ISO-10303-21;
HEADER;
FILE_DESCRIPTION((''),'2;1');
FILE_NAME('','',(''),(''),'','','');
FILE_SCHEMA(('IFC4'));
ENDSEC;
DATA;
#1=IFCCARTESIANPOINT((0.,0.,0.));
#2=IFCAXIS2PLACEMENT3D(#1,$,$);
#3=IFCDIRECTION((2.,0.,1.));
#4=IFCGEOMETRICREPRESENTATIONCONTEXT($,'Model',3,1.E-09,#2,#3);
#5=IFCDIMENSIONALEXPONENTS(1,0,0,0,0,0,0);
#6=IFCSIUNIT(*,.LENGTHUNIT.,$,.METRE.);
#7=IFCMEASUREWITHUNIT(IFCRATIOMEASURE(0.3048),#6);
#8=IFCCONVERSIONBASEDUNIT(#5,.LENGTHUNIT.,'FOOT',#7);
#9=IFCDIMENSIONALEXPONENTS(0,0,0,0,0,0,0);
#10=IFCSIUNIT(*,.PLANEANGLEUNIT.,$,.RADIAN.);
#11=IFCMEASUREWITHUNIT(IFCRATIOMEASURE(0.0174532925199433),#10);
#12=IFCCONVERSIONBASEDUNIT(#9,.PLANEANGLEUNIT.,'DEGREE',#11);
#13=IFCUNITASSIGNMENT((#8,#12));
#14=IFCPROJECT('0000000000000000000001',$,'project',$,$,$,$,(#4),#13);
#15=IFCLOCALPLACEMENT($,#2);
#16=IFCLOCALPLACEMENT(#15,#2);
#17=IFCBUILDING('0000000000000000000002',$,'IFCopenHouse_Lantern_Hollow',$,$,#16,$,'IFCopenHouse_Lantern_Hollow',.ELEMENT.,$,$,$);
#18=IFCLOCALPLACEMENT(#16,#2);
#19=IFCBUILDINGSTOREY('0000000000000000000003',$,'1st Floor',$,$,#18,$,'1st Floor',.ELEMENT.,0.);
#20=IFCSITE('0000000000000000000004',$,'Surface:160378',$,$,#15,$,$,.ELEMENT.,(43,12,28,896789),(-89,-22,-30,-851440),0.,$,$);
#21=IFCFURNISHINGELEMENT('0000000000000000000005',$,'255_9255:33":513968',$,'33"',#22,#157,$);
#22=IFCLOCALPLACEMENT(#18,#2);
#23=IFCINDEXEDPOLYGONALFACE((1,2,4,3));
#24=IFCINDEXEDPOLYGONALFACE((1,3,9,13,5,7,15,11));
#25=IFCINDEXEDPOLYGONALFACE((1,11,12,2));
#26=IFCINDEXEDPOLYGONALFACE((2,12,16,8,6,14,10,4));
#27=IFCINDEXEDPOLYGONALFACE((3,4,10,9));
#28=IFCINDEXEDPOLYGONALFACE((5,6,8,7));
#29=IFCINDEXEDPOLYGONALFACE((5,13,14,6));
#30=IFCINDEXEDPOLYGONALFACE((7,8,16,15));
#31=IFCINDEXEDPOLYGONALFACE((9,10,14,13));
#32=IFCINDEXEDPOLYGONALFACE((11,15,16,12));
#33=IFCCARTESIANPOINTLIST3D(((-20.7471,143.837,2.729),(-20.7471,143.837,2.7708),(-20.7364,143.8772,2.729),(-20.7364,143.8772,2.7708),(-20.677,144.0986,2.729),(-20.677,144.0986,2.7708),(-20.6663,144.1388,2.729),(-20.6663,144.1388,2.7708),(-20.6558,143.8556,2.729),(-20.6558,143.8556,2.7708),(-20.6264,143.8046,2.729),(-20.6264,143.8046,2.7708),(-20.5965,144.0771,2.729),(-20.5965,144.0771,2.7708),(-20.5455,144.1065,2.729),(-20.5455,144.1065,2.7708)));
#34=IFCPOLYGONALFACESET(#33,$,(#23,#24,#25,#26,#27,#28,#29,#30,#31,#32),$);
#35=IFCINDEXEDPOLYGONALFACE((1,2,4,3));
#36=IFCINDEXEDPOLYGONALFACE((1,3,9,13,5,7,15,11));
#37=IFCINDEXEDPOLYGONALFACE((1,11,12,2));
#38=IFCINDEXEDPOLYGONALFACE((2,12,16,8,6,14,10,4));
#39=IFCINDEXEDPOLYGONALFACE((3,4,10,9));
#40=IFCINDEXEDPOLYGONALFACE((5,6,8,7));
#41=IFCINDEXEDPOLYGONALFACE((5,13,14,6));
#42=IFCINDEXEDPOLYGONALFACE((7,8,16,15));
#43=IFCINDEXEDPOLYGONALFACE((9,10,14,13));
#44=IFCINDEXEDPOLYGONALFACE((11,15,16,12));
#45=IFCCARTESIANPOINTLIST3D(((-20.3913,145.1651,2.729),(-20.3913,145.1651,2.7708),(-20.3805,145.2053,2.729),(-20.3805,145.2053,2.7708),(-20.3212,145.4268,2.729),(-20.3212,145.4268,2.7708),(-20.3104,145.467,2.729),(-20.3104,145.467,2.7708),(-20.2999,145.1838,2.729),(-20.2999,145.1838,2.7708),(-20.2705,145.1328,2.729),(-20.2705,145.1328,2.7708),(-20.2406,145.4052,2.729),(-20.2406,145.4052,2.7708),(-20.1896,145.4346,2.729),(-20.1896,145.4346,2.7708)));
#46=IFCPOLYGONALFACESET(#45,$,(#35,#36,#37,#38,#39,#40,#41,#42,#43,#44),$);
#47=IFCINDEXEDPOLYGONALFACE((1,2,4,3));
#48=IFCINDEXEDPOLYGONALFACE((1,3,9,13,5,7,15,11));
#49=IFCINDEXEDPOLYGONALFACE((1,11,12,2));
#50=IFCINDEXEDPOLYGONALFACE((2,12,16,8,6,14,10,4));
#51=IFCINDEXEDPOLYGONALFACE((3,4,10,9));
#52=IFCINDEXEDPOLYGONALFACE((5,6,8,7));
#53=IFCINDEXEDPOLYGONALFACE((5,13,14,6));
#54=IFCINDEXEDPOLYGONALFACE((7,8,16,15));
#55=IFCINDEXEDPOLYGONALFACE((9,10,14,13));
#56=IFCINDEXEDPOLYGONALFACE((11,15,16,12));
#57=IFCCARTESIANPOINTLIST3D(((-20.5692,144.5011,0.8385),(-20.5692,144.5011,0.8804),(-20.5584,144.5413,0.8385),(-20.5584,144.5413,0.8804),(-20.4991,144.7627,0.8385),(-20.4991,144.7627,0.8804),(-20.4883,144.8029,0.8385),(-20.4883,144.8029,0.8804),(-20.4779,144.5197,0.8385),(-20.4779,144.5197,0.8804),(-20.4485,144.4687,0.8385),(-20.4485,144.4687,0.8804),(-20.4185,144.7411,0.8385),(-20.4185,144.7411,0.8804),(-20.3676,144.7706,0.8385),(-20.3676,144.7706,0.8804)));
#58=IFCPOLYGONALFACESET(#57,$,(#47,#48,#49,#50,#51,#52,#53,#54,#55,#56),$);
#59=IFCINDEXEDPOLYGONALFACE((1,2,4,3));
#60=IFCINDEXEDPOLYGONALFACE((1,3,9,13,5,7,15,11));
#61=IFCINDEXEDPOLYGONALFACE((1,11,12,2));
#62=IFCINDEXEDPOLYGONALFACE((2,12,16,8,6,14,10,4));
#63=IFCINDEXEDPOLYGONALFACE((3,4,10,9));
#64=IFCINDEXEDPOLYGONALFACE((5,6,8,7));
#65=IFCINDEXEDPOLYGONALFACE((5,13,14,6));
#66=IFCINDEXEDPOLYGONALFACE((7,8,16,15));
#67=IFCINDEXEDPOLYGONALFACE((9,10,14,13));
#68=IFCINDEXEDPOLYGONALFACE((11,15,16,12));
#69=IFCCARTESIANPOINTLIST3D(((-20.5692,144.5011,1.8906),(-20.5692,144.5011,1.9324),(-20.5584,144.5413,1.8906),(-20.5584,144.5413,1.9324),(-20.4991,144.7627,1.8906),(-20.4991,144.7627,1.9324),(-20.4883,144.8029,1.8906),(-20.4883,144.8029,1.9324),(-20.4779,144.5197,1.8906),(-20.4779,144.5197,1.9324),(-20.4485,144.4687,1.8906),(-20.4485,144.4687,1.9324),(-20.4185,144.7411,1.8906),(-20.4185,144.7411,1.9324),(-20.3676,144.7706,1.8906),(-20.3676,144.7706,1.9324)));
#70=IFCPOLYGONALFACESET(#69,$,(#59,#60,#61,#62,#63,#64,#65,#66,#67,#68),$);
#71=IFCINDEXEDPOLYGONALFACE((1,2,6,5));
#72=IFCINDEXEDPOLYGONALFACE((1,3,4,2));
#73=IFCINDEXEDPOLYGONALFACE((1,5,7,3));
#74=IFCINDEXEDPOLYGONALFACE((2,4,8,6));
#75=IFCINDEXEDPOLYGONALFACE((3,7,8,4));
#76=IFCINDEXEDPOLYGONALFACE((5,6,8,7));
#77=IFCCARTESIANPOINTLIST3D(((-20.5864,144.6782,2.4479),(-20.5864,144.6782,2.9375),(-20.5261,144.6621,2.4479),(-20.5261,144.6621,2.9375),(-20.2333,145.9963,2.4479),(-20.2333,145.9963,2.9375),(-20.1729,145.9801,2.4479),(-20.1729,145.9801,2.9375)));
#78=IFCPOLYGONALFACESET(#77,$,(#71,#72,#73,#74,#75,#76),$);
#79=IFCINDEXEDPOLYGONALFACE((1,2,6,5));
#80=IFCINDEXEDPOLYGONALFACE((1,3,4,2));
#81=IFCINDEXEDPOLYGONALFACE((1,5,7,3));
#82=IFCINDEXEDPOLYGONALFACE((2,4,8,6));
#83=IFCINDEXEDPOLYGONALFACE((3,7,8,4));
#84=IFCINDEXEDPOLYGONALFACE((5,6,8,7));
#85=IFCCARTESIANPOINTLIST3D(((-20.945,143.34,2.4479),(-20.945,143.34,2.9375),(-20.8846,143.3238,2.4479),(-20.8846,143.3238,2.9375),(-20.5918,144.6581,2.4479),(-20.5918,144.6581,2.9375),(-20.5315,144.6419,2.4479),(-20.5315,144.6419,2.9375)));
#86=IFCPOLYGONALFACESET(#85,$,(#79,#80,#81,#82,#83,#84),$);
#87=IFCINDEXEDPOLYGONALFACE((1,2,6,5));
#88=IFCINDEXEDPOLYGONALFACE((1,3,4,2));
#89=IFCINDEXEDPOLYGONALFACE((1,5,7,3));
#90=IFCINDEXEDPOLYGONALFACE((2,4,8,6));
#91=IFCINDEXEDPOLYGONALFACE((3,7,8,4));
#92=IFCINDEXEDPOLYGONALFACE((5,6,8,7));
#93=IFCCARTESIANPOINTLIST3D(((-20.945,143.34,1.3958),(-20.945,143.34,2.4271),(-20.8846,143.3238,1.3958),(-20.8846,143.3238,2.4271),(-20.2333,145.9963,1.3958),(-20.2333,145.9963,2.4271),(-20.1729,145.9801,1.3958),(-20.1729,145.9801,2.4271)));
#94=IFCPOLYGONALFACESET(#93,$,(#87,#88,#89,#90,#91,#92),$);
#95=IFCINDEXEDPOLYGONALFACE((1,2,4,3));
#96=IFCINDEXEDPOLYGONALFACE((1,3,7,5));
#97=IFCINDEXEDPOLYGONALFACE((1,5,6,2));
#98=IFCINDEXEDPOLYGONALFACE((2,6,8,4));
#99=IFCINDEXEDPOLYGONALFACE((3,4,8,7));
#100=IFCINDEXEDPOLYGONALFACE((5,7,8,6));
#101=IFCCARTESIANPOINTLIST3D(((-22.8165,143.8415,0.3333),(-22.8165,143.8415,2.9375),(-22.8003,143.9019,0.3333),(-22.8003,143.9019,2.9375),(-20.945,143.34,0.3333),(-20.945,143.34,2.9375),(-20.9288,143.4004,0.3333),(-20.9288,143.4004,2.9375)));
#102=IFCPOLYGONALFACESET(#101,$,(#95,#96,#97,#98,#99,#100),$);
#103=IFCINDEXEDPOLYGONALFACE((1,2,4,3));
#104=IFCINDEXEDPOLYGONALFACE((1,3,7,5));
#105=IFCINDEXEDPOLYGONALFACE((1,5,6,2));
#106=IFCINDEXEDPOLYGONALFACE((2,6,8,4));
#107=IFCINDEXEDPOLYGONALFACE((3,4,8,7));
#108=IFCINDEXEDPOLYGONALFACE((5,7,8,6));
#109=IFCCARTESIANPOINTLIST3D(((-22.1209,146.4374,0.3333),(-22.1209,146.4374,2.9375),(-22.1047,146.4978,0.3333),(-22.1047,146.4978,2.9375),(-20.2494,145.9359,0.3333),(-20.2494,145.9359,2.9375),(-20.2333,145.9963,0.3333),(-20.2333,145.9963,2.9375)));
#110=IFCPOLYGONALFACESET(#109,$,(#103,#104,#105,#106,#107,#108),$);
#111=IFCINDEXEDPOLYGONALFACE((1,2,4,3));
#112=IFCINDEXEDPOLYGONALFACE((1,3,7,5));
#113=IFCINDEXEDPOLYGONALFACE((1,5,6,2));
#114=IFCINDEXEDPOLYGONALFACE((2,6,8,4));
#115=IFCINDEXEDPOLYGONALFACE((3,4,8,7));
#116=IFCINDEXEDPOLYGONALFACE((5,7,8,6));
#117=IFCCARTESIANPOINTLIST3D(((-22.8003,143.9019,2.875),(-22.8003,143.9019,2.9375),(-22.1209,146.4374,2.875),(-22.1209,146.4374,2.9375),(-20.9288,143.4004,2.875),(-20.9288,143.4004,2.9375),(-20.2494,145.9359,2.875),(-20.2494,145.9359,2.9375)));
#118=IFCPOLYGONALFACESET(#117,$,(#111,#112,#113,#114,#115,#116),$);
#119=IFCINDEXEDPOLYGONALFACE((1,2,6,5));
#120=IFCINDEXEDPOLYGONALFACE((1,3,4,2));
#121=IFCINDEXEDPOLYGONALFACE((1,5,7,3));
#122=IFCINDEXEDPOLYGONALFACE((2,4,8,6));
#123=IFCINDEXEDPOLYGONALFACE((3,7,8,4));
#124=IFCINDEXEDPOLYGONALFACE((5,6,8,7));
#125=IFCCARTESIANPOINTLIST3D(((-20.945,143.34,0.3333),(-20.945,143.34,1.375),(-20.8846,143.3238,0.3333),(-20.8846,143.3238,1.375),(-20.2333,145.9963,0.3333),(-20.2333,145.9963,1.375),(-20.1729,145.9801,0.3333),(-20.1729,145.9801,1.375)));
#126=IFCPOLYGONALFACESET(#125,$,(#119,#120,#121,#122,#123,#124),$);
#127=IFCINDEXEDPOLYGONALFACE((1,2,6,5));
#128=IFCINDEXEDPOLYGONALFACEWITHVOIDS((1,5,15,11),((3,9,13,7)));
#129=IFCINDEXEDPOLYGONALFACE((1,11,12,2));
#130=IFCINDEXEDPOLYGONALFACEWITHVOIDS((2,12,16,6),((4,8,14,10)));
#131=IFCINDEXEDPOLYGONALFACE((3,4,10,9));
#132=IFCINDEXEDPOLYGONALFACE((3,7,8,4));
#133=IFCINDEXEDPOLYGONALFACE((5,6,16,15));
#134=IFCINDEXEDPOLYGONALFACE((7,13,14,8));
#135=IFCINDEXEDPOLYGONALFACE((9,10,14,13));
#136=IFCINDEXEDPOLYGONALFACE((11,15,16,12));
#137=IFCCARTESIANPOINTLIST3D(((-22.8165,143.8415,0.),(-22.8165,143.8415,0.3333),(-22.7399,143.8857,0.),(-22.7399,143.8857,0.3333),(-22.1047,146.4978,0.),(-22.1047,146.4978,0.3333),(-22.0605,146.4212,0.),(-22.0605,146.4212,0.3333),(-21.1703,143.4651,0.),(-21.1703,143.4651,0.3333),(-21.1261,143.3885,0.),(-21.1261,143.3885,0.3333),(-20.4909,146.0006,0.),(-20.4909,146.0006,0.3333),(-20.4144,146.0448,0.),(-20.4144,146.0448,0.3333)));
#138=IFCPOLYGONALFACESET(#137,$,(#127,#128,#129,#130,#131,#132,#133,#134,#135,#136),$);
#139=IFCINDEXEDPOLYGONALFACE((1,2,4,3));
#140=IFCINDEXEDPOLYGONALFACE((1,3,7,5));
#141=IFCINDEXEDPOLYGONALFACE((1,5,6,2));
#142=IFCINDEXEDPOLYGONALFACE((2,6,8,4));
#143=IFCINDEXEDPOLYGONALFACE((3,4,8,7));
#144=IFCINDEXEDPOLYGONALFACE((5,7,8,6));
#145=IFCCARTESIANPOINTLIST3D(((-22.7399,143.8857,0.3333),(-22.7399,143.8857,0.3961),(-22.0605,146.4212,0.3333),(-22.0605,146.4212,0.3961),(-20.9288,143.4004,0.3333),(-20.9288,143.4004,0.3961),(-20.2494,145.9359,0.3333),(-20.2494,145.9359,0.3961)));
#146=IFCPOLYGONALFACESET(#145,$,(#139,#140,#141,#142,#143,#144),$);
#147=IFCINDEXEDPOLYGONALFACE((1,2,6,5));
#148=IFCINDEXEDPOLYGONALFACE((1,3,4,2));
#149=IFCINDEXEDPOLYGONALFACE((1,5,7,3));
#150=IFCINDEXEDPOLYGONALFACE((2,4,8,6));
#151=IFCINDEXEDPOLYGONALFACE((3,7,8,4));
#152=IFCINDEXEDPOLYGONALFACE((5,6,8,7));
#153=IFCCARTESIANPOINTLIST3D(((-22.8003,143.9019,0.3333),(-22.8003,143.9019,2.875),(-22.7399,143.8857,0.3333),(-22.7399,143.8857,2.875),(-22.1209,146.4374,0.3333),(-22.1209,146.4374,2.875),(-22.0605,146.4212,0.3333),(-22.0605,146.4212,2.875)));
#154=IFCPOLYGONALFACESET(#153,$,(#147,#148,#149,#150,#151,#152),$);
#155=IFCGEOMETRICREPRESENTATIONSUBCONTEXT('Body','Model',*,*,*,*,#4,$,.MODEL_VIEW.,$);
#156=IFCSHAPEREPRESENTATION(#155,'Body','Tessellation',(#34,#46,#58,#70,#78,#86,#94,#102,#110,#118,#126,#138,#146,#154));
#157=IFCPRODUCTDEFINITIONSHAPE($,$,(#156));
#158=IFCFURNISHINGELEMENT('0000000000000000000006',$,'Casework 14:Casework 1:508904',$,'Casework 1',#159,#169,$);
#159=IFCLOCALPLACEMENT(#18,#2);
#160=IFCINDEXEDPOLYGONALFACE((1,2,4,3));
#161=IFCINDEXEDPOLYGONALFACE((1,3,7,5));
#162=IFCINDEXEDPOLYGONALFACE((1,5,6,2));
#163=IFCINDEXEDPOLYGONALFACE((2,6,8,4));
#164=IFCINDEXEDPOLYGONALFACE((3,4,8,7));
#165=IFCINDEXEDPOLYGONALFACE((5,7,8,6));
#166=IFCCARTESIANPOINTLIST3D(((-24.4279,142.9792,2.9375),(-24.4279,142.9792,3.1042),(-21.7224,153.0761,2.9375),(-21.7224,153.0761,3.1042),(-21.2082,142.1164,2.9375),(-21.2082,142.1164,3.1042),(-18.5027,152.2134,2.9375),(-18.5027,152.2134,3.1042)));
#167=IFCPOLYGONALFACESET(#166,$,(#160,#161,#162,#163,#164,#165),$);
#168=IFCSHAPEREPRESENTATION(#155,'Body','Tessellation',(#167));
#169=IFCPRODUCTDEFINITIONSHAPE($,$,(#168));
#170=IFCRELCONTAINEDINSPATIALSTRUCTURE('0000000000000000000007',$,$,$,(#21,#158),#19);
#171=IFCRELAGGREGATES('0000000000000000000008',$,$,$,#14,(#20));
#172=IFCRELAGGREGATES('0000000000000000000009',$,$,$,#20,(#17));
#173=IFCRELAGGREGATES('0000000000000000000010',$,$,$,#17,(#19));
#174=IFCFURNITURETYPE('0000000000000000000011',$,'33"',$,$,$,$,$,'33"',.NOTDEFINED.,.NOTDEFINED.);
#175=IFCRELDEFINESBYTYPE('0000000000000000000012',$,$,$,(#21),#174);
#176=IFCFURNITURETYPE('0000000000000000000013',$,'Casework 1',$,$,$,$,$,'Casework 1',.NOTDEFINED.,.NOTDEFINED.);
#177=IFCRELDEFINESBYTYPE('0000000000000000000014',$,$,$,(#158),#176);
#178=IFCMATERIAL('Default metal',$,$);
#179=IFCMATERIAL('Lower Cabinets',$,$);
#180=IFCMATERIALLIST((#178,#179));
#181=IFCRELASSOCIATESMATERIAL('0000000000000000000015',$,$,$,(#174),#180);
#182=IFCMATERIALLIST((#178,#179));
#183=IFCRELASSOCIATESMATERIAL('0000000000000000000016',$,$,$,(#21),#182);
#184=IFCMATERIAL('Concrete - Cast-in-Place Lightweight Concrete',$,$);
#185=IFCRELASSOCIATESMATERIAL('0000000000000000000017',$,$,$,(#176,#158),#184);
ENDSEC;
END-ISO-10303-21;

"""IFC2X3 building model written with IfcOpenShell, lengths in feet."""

from ifc_helpers import new_model, entity, si_unit, converted_unit, direction, frame, frame_2d, origin, origin_2d_with_axis, place, context, subcontext, project, spatial, polyline, rectangle, outline, extrude, source, transform, mapped, material, material_list, type_object, type_shapes, element, save


model = new_model("IFC2X3")

# Units and contexts
model_context = context("Model", 3, precision=1e-09, world=origin(), true_north=direction((2.0, 0.0, 1.0)))
body_context = subcontext(model_context, "Body", "Model", "MODEL_VIEW")
ifc_project = project(units=[converted_unit("LENGTHUNIT", "FOOT", entity("IfcRatioMeasure", 0.3048), si_unit("LENGTHUNIT", "METRE"), dimensions=[1, 0, 0, 0, 0, 0, 0]), converted_unit("PLANEANGLEUNIT", "DEGREE", entity("IfcRatioMeasure", 0.0174532925199433), si_unit("PLANEANGLEUNIT", "RADIAN"), dimensions=[0, 0, 0, 0, 0, 0, 0])], contexts=[model_context])

# Site, building, storey
site_placement = place(None, origin())
site = spatial("IfcSite", under=ifc_project, at=site_placement, Name="Surface:160378", CompositionType="ELEMENT", RefLatitude=(43, 12, 28, 896789), RefLongitude=(-89, -22, -30, -851440), RefElevation=0.0)
building_placement = place(site_placement, origin())
building = spatial("IfcBuilding", under=site, at=building_placement, Name="IFCopenHouse_Lantern_Hollow", LongName="IFCopenHouse_Lantern_Hollow", CompositionType="ELEMENT")
storey_placement = place(building_placement, origin())
storey = spatial("IfcBuildingStorey", under=building, at=storey_placement, Name="1st Floor", LongName="1st Floor", CompositionType="ELEMENT", Elevation=0.0)

# Furnishing elements
ifc_material_1 = material(Name="Default metal")
ifc_material_2 = material(Name="Lower Cabinets")
ifc_material_list_1 = material_list([ifc_material_1, ifc_material_2])
ifc_material_list_2 = material_list([ifc_material_1, ifc_material_2])
furniture_type_1 = type_object("IfcFurnitureType", Name="33\"", ElementType="33\"", AssemblyPlace="NOTDEFINED", material=ifc_material_list_2)
shared_shape_1 = source(origin(), body_context, "Body", "SweptSolid", [
    extrude(outline(polyline([(-0.0521, -0.1562), (0.0729, -0.1562), (0.0729, 0.1562), (-0.0521, 0.1562), (-0.0521, 0.1146), (0.0313, 0.1146), (0.0313, -0.1146), (-0.0521, -0.1146), (-0.0521, -0.1562)])), frame((-0.626, -2.0521, 2.729), z_axis=(0.0, 0.0, 1.0), x_axis=(0.0, -1.0, 0.0)), (0.0, 0.0, 1.0), 0.0418),
    extrude(outline(polyline([(-0.0521, -0.1562), (0.0729, -0.1562), (0.0729, 0.1562), (-0.0521, 0.1562), (-0.0521, 0.1146), (0.0313, 0.1146), (0.0313, -0.1146), (-0.0521, -0.1146), (-0.0521, -0.1562)])), frame((0.749, -2.0521, 2.729), z_axis=(0.0, 0.0, 1.0), x_axis=(0.0, -1.0, 0.0)), (0.0, 0.0, 1.0), 0.0418),
    extrude(outline(polyline([(-0.0521, -0.1562), (0.0729, -0.1562), (0.0729, 0.1562), (-0.0521, 0.1562), (-0.0521, 0.1146), (0.0313, 0.1146), (0.0313, -0.1146), (-0.0521, -0.1146), (-0.0521, -0.1562)])), frame((0.0615, -2.0521, 0.8385), z_axis=(0.0, 0.0, 1.0), x_axis=(0.0, -1.0, 0.0)), (0.0, 0.0, 1.0), 0.0418),
    extrude(outline(polyline([(-0.0521, -0.1562), (0.0729, -0.1562), (0.0729, 0.1562), (-0.0521, 0.1562), (-0.0521, 0.1146), (0.0313, 0.1146), (0.0313, -0.1146), (-0.0521, -0.1146), (-0.0521, -0.1562)])), frame((0.0615, -2.0521, 1.8906), z_axis=(0.0, 0.0, 1.0), x_axis=(0.0, -1.0, 0.0)), (0.0, 0.0, 1.0), 0.0418),
    extrude(rectangle(XDim=0.0625, YDim=1.3646, at=frame_2d((0.0, 0.0), x_axis=(1.0, 0.0))), frame((0.7542, -1.9688, 2.4479), z_axis=(0.0, 0.0, 1.0), x_axis=(0.0, 1.0, 0.0)), (0.0, 0.0, 1.0), 0.4896),
    extrude(rectangle(XDim=0.0625, YDim=1.3646, at=origin_2d_with_axis()), frame((-0.6312, -1.9688, 2.4479), z_axis=(0.0, 0.0, 1.0), x_axis=(0.0, 1.0, 0.0)), (0.0, 0.0, 1.0), 0.4896),
    extrude(rectangle(XDim=0.0625, YDim=2.75, at=frame_2d((0.0, 0.0), x_axis=(1.0, 0.0))), frame((0.0615, -1.9688, 1.3958), z_axis=(0.0, 0.0, 1.0), x_axis=(0.0, 1.0, 0.0)), (0.0, 0.0, 1.0), 1.0313),
    extrude(rectangle(XDim=0.0625, YDim=1.9375, at=frame_2d((0.0, 0.0), x_axis=(1.0, 0.0))), frame((-1.2823, -0.9687, 0.3333)), (0.0, 0.0, 1.0), 2.6042),
    extrude(rectangle(XDim=0.0625, YDim=1.9375, at=frame_2d((0.0, 0.0), x_axis=(1.0, 0.0))), frame((1.4052, -0.9687, 0.3333)), (0.0, 0.0, 1.0), 2.6042),
    extrude(rectangle(XDim=2.625, YDim=1.9375, at=origin_2d_with_axis()), frame((0.0615, -0.9688, 2.875), z_axis=(0.0, 0.0, 1.0), x_axis=(-1.0, 0.0, 0.0)), (0.0, 0.0, 1.0), 0.0625),
    extrude(rectangle(XDim=0.0625, YDim=2.75, at=frame_2d((0.0, 0.0), x_axis=(1.0, 0.0))), frame((0.0615, -1.9688, 0.3333), z_axis=(0.0, 0.0, 1.0), x_axis=(0.0, 1.0, 0.0)), (0.0, 0.0, 1.0), 1.0417),
    extrude(outline(polyline([(-1.375, -0.875), (1.375, -0.875), (1.375, 0.875), (-1.375, 0.875), (-1.375, -0.875)]), holes=[polyline([(-1.3125, -0.8125), (-1.3125, 0.8125), (1.3125, 0.8125), (1.3125, -0.8125), (-1.3125, -0.8125)])]), frame((0.0615, -0.875, 0.0)), (0.0, 0.0, 1.0), 0.3333),
    extrude(rectangle(XDim=2.625, YDim=1.875, at=frame_2d((0.0, 0.0), x_axis=(1.0, 0.0))), frame((0.0615, -1.0, 0.3333), z_axis=(0.0, 0.0, 1.0), x_axis=(-1.0, 0.0, 0.0)), (0.0, 0.0, 1.0), 0.0627),
    extrude(rectangle(XDim=0.0625, YDim=2.625, at=origin_2d_with_axis()), frame((0.0615, -0.0312, 0.3333), z_axis=(0.0, 0.0, 1.0), x_axis=(0.0, 1.0, 0.0)), (0.0, 0.0, 1.0), 2.5417),
])
type_shapes(furniture_type_1, [shared_shape_1])
furnishing_1_placement = place(storey_placement, frame((-22.4765, 145.1102, 0.0), z_axis=(0.0, 0.0, 1.0), x_axis=(0.258819, 0.965926, 0.0)))
element("IfcFurnishingElement", 1, at=furnishing_1_placement, inside=storey, type_object=furniture_type_1, material=ifc_material_list_1, Name="255_9255:33\":513968", ObjectType="33\"", context=body_context, shape_type="MappedRepresentation", body=[
    mapped(shared_shape_1, transform((0.0, 0.0, 0.0), scale=1.0)),
])
ifc_material_3 = material(Name="Concrete - Cast-in-Place Lightweight Concrete")
furniture_type_2 = type_object("IfcFurnitureType", Name="Casework 1", ElementType="Casework 1", AssemblyPlace="NOTDEFINED", material=ifc_material_3)
shared_shape_2 = source(origin(), body_context, "Body", "SweptSolid", [
    extrude(rectangle(XDim=10.4532, YDim=3.3333, at=origin_2d_with_axis()), frame((2.9626, 5.4798, 0.0), z_axis=(0.0, 0.0, 1.0), x_axis=(-0.258819, -0.965926, 0.0)), (0.0, 0.0, 1.0), 0.1667),
])
type_shapes(furniture_type_2, [shared_shape_2])
furnishing_2_placement = place(storey_placement, frame((-24.4279, 142.1164, 2.9375)))
element("IfcFurnishingElement", 2, at=furnishing_2_placement, inside=storey, type_object=furniture_type_2, material=ifc_material_3, Name="Casework 14:Casework 1:508904", ObjectType="Casework 1", context=body_context, shape_type="MappedRepresentation", body=[
    mapped(shared_shape_2, transform((0.0, 0.0, 0.0), scale=1.0)),
])

save(model, "model.ifc")
